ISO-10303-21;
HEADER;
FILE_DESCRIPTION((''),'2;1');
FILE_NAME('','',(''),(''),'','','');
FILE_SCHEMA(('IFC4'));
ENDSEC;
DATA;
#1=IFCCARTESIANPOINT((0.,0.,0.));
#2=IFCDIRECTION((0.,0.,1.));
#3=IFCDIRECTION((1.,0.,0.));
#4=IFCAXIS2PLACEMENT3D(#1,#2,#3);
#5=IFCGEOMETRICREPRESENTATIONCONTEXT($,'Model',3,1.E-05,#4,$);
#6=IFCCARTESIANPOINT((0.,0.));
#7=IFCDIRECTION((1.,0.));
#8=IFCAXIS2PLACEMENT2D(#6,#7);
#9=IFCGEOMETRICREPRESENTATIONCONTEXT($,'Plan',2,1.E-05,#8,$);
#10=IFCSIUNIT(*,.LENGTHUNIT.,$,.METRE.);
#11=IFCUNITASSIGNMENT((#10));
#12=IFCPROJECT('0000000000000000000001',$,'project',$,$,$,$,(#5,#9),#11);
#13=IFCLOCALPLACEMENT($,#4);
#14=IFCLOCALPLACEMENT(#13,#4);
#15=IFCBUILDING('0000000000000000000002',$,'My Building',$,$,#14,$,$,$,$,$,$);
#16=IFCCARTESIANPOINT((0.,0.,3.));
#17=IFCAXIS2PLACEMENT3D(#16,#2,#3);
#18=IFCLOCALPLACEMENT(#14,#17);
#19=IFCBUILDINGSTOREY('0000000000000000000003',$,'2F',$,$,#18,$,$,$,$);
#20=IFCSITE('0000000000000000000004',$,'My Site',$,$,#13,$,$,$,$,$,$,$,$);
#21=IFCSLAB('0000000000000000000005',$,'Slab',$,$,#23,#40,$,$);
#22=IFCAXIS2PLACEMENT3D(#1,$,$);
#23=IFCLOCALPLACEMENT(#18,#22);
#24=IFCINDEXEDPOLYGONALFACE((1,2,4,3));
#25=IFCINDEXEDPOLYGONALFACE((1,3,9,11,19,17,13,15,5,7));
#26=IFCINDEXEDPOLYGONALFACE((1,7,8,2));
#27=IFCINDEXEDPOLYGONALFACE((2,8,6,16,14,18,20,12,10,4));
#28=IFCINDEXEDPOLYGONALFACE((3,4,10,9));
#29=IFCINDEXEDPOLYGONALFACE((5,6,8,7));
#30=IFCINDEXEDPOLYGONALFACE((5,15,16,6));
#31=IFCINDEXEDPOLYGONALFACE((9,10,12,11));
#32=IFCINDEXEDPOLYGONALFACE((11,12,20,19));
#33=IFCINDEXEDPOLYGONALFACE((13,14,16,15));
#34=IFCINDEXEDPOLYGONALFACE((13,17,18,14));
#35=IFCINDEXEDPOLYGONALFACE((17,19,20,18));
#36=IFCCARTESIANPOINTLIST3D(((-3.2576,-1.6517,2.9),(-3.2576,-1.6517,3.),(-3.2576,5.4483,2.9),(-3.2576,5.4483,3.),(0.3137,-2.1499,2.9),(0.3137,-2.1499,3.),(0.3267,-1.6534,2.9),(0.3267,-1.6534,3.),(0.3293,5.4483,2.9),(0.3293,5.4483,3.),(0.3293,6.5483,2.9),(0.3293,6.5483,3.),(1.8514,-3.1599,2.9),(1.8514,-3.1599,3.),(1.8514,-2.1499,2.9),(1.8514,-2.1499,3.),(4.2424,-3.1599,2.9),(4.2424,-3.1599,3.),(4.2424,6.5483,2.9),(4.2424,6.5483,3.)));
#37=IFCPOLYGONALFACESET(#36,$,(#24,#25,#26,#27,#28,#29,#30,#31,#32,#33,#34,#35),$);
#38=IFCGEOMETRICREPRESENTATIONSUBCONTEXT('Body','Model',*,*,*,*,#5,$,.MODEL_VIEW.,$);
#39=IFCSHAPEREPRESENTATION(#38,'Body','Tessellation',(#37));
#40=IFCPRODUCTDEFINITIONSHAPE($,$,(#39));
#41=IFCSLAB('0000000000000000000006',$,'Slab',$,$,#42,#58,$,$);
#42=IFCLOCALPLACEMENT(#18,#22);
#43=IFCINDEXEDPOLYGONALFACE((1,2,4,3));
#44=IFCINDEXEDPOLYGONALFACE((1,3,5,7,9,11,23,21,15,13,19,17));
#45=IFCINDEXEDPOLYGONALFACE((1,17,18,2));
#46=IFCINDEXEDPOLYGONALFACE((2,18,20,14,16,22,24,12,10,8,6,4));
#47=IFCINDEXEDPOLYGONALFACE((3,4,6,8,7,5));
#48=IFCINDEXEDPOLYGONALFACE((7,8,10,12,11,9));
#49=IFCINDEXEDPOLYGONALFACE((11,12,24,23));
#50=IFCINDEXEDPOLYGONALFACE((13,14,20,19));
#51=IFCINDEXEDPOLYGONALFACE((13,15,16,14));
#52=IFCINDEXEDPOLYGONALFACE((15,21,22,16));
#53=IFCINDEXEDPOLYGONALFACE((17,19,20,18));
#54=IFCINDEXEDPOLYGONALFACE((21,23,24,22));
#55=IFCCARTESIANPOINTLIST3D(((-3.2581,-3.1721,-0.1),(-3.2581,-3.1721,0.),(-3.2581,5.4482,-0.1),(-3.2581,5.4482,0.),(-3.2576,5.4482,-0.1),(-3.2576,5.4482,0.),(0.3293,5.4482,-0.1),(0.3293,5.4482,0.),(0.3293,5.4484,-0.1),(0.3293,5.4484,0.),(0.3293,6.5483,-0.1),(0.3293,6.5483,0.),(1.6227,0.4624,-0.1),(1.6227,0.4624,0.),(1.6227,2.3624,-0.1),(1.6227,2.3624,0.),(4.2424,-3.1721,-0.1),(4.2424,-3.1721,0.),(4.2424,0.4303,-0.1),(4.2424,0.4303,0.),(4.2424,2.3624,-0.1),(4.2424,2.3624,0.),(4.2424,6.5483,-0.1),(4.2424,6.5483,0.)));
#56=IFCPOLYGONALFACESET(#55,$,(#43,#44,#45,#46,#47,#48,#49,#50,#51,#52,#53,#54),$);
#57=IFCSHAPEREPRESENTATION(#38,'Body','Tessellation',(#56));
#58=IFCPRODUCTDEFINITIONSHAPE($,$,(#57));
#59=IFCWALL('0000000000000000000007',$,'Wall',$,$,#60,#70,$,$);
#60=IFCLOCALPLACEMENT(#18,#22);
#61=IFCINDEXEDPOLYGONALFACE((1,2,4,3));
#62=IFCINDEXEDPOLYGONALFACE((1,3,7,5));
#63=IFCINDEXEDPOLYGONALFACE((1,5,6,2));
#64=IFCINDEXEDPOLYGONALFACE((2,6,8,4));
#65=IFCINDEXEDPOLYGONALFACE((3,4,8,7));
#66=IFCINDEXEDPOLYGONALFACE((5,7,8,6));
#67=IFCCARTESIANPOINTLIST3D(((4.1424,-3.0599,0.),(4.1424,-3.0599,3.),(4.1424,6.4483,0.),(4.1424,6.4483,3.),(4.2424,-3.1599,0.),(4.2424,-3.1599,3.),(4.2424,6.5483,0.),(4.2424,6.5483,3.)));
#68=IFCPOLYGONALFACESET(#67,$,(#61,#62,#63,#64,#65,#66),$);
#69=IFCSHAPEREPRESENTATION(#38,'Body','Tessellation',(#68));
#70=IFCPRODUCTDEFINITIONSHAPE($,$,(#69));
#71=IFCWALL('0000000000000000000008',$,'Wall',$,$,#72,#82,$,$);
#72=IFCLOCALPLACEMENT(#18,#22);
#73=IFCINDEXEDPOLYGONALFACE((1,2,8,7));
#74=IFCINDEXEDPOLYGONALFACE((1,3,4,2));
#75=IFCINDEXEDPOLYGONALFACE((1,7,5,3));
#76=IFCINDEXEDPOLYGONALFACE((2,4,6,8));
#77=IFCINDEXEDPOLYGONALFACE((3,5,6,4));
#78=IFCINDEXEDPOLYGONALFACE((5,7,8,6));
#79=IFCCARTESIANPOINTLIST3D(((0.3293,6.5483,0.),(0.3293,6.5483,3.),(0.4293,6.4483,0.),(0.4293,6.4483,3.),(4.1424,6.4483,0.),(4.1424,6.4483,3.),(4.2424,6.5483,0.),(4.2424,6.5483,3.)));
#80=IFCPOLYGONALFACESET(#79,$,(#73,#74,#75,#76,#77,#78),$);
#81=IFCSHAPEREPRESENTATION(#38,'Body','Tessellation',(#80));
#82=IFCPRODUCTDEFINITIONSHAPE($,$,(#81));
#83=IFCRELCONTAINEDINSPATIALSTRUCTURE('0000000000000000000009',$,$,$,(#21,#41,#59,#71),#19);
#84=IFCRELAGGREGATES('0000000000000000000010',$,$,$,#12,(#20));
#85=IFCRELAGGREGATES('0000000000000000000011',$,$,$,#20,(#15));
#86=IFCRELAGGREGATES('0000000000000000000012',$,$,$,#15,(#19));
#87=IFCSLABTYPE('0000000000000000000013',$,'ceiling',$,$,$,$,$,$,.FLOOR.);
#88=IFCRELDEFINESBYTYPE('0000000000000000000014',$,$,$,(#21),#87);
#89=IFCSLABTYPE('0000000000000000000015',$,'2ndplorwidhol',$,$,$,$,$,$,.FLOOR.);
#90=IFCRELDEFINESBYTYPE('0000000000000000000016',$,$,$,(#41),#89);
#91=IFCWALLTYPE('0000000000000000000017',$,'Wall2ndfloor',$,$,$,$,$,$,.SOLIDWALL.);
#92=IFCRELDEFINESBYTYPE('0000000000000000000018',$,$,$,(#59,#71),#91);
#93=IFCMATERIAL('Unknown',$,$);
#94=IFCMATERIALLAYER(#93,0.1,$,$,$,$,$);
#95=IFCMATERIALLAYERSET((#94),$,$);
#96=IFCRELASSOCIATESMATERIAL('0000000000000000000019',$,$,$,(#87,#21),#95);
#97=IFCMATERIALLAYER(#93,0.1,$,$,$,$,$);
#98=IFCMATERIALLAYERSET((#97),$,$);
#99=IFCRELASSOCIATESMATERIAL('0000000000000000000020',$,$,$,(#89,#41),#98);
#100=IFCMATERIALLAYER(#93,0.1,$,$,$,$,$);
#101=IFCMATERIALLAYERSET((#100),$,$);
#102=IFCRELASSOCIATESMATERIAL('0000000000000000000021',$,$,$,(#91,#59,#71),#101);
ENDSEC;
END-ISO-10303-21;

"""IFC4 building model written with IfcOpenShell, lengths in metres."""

from ifc_helpers import new_model, si_unit, frame, origin_with_axes, origin_2d_with_axis, place, context, subcontext, project, spatial, line, indexed_curve, outline, extrude, material, layer, layer_set, layer_usage, type_object, element, save


model = new_model("IFC4")

# Units and contexts
model_context = context("Model", 3, precision=1e-05, world=origin_with_axes())
plan_context = context("Plan", 2, precision=1e-05, world=origin_2d_with_axis())
body_context_1 = subcontext(model_context, "Body", "Model", "MODEL_VIEW")
ifc_project = project(units=[si_unit("LENGTHUNIT", "METRE")], contexts=[model_context, plan_context])

# Site, building, storey
site_placement = place(None, origin_with_axes())
site = spatial("IfcSite", under=ifc_project, at=site_placement, Name="My Site")
building_placement = place(site_placement, origin_with_axes())
building = spatial("IfcBuilding", under=site, at=building_placement, Name="My Building")
storey_placement = place(building_placement, frame((0.0, 0.0, 3.0), z_axis=(0.0, 0.0, 1.0), x_axis=(1.0, 0.0, 0.0)))
storey = spatial("IfcBuildingStorey", under=building, at=storey_placement, Name="2F")

# Slabs
ifc_material = material(Name="Unknown")
ifc_layer_1 = layer(ifc_material, 0.1)
ifc_layer_set_1 = layer_set([ifc_layer_1])
ifc_layer_usage_1 = layer_usage(ifc_layer_set_1, "AXIS3", "POSITIVE", -0.1)
slab_type_1 = type_object("IfcSlabType", Name="ceiling", PredefinedType="FLOOR", material=ifc_layer_set_1)
slab_1_placement = place(storey_placement, frame((-3.2576, 5.4483, 3.0), z_axis=(0.0, 0.0, 1.0), x_axis=(1.0, 0.0, 0.0)))
element("IfcSlab", 1, at=slab_1_placement, inside=storey, type_object=slab_type_1, material=ifc_layer_usage_1, Name="Slab", context=body_context_1, shape_type="SweptSolid", body=[
    extrude(outline(indexed_curve([(0.0, 0.0), (0.0, -7.1), (3.5843, -7.1017), (3.5713, -7.5982), (5.109, -7.5982), (5.109, -8.6082), (7.5, -8.6082), (7.5, 1.1), (3.5869, 1.1), (3.5869, 0.0), (0.0, 0.0)])), frame((0.0, 0.0, -0.1), z_axis=(0.0, 0.0, 1.0), x_axis=(1.0, 0.0, 0.0)), (0.0, 0.0, 1.0), 0.1),
])
ifc_layer_2 = layer(ifc_material, 0.1)
ifc_layer_set_2 = layer_set([ifc_layer_2])
ifc_layer_usage_2 = layer_usage(ifc_layer_set_2, "AXIS3", "POSITIVE", -0.1)
slab_type_2 = type_object("IfcSlabType", Name="2ndplorwidhol", PredefinedType="FLOOR", material=ifc_layer_set_2)
slab_2_placement = place(storey_placement, frame((1.6227, 0.4624, 0.0), z_axis=(0.0, 0.0, 1.0), x_axis=(1.0, 0.0, 0.0)))
element("IfcSlab", 2, at=slab_2_placement, inside=storey, type_object=slab_type_2, material=ifc_layer_usage_2, Name="Slab", context=body_context_1, shape_type="SweptSolid", body=[
    extrude(outline(indexed_curve([(0.0, 0.0), (0.0, 1.9), (2.6196, 1.9), (2.6196, 6.0859), (-1.2935, 6.0859), (-1.2935, 4.9859), (-1.2935, 4.9858), (-4.8804, 4.9858), (-4.8808, 4.9858), (-4.8808, -3.6345), (2.6196, -3.6345), (2.6196, -0.0321), (0.0, 0.0)])), frame((0.0, 0.0, -0.1), z_axis=(0.0, 0.0, 1.0), x_axis=(1.0, 0.0, 0.0)), (0.0, 0.0, 1.0), 0.1),
])

# Walls
ifc_layer_3 = layer(ifc_material, 0.1)
ifc_layer_set_3 = layer_set([ifc_layer_3])
ifc_layer_usage_3 = layer_usage(ifc_layer_set_3, "AXIS2", "POSITIVE", 0.0)
wall_type = type_object("IfcWallType", Name="Wall2ndfloor", PredefinedType="SOLIDWALL", material=ifc_layer_set_3)
wall_1_placement = place(storey_placement, frame((4.2424, -3.1599, 0.0), z_axis=(0.0, 0.0, 1.0), x_axis=(0.0, 1.0, 0.0)))
element("IfcWall", 3, at=wall_1_placement, inside=storey, type_object=wall_type, material=ifc_layer_usage_3, Name="Wall", context=body_context_1, shape_type="SweptSolid", body=[
    extrude(outline(indexed_curve([(0.0, 0.0), (0.1, 0.1), (9.6082, 0.1), (9.7082, 0.0)], segments=[line(1, 2, 3, 4, 1)])), origin_with_axes(), (0.0, 0.0, 1.0), 3.0),
])
ifc_layer_usage_4 = layer_usage(ifc_layer_set_3, "AXIS2", "POSITIVE", 0.0)
wall_2_placement = place(storey_placement, frame((4.2424, 6.5483, 0.0), z_axis=(0.0, 0.0, 1.0), x_axis=(-1.0, 0.0, 0.0)))
element("IfcWall", 4, at=wall_2_placement, inside=storey, type_object=wall_type, material=ifc_layer_usage_4, Name="Wall", context=body_context_1, shape_type="SweptSolid", body=[
    extrude(outline(indexed_curve([(0.0, 0.0), (0.1, 0.1), (3.8131, 0.1), (3.9131, 0.0)], segments=[line(1, 2, 3, 4, 1)])), origin_with_axes(), (0.0, 0.0, 1.0), 3.0),
])

save(model, "model.ifc")
